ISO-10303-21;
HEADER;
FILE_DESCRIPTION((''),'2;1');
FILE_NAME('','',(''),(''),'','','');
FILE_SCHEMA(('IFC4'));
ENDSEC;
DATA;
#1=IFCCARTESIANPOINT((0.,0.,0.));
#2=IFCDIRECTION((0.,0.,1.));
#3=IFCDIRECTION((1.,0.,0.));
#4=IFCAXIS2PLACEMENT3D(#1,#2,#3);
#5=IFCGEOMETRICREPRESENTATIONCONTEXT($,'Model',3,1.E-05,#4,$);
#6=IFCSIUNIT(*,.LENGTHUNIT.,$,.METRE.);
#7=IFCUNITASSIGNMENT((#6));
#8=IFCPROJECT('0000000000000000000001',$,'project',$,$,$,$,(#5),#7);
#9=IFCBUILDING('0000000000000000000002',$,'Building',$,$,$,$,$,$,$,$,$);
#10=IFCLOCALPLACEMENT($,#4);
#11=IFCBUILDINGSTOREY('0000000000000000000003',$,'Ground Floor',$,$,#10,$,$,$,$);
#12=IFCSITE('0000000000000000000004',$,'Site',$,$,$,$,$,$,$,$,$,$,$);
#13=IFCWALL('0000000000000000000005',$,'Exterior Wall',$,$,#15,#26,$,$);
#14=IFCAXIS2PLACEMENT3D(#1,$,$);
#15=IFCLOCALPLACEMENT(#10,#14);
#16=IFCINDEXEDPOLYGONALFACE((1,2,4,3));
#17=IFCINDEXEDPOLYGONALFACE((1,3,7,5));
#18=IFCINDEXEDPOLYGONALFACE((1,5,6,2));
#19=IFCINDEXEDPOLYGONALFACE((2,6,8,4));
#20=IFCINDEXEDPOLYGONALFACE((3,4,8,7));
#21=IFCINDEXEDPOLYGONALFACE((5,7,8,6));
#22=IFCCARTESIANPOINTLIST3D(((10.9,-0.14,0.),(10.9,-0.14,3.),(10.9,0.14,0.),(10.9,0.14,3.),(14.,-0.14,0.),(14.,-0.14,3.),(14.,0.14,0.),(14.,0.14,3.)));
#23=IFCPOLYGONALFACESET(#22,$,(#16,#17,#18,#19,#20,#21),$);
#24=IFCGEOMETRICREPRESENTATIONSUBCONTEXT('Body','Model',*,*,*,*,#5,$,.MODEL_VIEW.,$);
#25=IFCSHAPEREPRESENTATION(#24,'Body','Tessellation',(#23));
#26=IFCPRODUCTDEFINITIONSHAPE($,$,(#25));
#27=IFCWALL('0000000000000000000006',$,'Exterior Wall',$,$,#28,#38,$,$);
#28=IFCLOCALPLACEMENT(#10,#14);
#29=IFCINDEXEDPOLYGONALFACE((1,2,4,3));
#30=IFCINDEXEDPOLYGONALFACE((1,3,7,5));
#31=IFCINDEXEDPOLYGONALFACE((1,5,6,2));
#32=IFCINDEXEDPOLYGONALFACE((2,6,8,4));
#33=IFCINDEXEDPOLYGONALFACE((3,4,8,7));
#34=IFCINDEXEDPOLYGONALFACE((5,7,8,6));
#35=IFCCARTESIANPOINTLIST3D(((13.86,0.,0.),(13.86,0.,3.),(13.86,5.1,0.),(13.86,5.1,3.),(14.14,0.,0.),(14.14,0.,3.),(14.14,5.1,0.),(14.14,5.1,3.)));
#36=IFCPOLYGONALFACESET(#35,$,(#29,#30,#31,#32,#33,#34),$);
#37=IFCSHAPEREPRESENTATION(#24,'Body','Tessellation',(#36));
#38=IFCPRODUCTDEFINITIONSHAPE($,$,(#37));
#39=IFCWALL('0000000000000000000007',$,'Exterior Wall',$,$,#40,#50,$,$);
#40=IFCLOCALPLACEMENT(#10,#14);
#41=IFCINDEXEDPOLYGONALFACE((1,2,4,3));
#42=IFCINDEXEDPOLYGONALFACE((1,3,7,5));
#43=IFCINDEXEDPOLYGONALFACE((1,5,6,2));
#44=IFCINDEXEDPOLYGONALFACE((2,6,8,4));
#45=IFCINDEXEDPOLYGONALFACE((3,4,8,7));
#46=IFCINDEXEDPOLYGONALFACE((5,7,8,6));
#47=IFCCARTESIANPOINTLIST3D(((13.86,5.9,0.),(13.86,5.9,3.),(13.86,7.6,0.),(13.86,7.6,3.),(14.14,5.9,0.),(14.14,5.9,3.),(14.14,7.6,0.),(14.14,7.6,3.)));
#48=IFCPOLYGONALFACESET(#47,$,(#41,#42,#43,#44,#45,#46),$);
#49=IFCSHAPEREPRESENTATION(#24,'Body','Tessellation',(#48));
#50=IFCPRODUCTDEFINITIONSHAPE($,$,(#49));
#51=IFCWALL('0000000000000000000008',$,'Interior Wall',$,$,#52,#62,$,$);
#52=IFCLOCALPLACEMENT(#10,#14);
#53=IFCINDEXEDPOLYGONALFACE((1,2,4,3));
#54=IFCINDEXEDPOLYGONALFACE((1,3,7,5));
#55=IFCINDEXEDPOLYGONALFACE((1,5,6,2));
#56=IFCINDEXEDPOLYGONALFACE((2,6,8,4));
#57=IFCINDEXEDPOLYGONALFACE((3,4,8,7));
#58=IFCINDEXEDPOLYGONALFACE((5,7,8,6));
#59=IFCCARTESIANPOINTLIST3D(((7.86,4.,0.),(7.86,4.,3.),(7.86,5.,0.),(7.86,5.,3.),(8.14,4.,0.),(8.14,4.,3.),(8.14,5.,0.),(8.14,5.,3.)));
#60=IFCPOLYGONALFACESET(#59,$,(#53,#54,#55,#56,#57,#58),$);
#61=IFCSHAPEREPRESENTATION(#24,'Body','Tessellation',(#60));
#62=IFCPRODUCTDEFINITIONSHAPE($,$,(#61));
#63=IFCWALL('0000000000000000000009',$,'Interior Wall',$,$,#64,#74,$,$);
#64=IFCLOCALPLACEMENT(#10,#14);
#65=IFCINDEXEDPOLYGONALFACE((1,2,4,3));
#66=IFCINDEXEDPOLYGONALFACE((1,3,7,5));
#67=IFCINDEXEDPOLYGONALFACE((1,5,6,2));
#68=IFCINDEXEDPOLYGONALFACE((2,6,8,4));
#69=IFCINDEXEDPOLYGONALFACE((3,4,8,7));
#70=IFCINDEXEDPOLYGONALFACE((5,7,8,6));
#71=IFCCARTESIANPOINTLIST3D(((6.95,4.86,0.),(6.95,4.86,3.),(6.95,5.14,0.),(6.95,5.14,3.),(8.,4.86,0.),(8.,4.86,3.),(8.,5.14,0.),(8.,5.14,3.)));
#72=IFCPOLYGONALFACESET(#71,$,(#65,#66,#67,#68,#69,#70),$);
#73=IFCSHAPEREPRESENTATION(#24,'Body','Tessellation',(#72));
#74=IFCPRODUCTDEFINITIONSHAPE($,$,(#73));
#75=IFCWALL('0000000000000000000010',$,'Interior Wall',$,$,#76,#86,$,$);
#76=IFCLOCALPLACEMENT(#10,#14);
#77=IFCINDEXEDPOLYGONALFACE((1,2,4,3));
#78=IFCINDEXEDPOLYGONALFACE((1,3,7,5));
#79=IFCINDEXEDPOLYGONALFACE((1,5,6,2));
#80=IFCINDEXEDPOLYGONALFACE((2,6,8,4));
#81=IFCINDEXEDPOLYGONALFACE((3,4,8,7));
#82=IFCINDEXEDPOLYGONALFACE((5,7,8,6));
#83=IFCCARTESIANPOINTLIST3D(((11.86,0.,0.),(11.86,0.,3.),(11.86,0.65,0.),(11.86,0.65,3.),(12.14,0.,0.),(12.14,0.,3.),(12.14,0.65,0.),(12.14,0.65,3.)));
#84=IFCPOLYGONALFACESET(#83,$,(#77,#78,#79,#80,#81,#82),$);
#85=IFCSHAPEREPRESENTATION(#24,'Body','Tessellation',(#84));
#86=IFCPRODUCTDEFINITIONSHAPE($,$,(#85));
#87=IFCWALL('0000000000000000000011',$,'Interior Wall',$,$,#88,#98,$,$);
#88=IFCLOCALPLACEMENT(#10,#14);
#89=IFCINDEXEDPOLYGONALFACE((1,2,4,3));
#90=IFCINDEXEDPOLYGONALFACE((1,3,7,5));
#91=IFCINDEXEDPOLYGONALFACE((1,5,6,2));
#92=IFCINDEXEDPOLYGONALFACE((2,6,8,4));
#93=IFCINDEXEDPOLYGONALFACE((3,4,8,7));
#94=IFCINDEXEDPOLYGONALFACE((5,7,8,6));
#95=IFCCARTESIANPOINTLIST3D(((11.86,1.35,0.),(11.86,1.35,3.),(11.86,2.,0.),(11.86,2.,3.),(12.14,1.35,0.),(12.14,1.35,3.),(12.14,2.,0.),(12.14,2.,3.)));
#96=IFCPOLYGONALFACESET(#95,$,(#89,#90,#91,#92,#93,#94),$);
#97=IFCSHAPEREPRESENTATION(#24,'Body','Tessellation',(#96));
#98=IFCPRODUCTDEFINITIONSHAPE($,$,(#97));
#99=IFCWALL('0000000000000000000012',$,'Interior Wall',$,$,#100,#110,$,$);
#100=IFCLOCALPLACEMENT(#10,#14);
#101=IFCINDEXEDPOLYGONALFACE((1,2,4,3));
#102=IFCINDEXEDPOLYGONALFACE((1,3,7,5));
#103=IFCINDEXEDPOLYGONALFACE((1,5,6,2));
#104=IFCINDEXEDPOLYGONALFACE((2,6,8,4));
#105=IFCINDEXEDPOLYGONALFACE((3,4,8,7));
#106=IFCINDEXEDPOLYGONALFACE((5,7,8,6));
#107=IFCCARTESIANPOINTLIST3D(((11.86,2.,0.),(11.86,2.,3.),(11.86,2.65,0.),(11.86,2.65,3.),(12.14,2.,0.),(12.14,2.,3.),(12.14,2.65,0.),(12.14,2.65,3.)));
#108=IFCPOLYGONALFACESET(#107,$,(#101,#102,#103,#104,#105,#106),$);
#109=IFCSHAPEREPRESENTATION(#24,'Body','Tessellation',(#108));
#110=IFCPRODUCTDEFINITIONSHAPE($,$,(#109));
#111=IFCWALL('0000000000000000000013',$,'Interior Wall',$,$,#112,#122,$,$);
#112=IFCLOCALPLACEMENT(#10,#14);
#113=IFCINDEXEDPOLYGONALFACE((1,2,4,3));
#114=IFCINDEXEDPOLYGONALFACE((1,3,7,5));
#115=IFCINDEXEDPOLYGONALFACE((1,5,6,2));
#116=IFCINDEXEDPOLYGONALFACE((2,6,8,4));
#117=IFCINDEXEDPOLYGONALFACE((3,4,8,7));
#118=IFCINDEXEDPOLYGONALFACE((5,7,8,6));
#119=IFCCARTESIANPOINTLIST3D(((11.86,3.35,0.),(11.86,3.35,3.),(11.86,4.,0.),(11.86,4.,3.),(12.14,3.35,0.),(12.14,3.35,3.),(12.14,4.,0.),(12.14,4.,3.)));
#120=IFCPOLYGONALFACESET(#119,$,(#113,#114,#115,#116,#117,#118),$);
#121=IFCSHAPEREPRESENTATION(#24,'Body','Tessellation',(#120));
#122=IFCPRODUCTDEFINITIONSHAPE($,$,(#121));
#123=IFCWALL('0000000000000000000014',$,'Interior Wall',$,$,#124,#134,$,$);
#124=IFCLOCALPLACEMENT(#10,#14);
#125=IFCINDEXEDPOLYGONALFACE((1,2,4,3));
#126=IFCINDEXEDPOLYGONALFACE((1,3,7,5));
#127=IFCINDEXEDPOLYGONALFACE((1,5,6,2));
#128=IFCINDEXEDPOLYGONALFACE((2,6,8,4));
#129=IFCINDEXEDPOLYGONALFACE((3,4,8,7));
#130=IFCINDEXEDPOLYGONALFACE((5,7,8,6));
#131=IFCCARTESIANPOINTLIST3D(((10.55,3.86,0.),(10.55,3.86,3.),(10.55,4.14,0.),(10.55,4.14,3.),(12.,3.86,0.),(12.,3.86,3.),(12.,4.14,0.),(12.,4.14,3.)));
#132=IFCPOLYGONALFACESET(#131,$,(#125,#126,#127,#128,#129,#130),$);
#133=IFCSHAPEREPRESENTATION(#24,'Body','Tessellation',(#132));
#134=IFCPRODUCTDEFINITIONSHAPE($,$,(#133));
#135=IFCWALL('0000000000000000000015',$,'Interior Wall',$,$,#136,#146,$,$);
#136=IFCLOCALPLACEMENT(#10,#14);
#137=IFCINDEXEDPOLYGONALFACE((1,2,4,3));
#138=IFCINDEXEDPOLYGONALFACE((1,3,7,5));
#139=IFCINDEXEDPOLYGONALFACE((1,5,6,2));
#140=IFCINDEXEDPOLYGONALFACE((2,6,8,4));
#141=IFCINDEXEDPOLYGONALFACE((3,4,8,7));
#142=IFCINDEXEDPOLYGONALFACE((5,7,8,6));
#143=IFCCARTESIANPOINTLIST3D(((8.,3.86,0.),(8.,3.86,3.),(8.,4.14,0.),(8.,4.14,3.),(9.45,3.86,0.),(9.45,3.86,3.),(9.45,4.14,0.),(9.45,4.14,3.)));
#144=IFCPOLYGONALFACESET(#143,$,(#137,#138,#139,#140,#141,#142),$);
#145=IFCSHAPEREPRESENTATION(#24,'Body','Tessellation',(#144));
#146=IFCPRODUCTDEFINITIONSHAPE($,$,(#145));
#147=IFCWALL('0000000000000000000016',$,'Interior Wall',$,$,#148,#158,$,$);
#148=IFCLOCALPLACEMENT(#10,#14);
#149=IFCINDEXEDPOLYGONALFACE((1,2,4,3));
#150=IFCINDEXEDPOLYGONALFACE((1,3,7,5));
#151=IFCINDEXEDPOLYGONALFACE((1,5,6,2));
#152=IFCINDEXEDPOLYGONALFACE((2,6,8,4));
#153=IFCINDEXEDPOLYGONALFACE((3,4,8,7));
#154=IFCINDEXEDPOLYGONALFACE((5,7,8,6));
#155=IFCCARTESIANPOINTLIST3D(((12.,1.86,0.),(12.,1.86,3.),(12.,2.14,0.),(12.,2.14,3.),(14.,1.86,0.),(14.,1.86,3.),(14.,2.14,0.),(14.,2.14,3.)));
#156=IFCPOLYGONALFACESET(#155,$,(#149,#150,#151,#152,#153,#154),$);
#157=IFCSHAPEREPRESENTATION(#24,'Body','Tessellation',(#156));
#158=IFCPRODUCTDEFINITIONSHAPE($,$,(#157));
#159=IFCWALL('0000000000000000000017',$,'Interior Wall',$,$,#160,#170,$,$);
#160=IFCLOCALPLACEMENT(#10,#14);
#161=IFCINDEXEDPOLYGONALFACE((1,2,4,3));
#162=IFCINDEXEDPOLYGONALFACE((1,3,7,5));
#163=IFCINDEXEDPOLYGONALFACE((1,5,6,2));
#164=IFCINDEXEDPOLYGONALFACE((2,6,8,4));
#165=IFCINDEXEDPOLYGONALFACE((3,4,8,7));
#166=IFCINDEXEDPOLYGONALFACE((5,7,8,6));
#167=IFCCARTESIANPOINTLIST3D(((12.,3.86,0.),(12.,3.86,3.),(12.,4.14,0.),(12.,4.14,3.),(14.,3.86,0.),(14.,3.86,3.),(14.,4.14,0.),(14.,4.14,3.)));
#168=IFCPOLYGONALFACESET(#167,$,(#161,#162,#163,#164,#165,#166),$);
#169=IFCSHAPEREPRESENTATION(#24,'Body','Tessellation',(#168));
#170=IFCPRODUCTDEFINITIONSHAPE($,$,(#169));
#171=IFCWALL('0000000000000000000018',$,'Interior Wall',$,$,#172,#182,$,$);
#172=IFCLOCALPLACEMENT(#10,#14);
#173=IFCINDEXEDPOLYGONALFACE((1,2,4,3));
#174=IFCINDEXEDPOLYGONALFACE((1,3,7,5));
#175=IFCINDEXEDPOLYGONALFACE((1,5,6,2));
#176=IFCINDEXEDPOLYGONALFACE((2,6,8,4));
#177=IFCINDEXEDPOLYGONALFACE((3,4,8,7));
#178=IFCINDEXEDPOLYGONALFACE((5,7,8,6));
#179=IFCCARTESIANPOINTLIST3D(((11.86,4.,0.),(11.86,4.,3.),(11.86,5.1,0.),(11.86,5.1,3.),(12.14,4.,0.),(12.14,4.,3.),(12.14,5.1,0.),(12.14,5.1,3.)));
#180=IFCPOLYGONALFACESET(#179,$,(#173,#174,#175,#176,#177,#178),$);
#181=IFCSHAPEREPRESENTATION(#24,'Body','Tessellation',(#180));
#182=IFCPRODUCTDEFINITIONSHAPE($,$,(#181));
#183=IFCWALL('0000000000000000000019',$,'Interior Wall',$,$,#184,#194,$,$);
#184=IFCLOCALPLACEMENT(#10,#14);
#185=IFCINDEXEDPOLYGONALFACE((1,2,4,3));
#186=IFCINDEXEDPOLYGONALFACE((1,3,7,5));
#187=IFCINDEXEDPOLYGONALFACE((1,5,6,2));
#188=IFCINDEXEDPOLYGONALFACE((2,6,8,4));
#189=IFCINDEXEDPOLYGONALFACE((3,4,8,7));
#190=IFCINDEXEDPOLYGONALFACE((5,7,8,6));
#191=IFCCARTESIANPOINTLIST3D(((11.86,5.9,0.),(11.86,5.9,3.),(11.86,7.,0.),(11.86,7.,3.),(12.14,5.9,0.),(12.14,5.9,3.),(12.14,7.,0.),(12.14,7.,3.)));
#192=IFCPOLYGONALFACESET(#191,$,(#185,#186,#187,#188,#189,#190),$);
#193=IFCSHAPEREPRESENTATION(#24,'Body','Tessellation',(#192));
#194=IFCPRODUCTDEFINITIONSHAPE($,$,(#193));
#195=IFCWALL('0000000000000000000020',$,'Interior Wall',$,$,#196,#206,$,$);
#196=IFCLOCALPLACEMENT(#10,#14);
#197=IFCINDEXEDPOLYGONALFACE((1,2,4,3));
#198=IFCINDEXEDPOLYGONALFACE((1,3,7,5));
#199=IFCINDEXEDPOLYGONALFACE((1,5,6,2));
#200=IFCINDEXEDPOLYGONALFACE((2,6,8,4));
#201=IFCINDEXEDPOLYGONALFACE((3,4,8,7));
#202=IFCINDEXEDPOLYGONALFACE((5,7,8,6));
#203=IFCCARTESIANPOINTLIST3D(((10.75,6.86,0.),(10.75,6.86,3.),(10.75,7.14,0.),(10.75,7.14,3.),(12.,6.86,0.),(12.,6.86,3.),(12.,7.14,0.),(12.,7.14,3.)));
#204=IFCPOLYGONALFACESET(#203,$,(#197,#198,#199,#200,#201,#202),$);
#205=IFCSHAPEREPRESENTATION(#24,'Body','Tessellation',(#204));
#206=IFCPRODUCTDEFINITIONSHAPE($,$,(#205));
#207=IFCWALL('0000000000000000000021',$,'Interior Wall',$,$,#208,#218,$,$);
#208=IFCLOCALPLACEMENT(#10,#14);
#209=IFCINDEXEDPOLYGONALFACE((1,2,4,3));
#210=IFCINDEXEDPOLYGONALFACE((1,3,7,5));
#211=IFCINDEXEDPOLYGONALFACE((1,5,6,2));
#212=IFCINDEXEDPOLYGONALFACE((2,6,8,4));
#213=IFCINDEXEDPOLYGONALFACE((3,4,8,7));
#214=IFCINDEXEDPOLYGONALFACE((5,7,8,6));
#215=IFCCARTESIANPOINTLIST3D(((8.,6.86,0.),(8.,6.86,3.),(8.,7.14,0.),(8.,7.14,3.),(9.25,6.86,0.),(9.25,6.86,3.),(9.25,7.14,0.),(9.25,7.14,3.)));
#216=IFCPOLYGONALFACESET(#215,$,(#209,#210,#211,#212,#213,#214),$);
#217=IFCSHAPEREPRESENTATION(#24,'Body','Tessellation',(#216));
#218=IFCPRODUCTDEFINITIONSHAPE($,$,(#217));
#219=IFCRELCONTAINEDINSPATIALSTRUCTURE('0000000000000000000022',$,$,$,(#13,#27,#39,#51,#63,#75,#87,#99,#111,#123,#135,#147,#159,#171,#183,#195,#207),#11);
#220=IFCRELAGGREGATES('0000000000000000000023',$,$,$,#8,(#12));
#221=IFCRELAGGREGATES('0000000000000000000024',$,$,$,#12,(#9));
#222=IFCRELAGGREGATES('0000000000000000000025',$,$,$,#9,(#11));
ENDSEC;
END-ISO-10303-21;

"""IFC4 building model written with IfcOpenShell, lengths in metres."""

from ifc_helpers import new_model, si_unit, frame, origin_with_axes, place, context, subcontext, project, spatial, indexed_curve, outline, extrude, element, save


model = new_model("IFC4")

# Units and contexts
model_context = context("Model", 3, precision=1e-05, world=origin_with_axes())
body_context = subcontext(model_context, "Body", "Model", "MODEL_VIEW")
ifc_project = project(units=[si_unit("LENGTHUNIT", "METRE")], contexts=[model_context])

# Site, building, storey
site = spatial("IfcSite", under=ifc_project, Name="Site")
building = spatial("IfcBuilding", under=site, Name="Building")
storey_placement = place(None, origin_with_axes())
storey = spatial("IfcBuildingStorey", under=building, at=storey_placement, Name="Ground Floor")

# Walls
wall_1_placement = place(storey_placement, frame((10.9, 0.0, 0.0), z_axis=(0.0, 0.0, 1.0), x_axis=(1.0, 0.0, 0.0)))
element("IfcWall", 1, at=wall_1_placement, inside=storey, Name="Exterior Wall", context=body_context, shape_type="SweptSolid", body=[
    extrude(outline(indexed_curve([(0.0, 0.0), (0.0, 0.28), (3.1, 0.28), (3.1, 0.0), (0.0, 0.0)], self_intersect=False)), frame((0.0, -0.14, 0.0), z_axis=(0.0, 0.0, 1.0), x_axis=(1.0, 0.0, 0.0)), (0.0, 0.0, 1.0), 3.0),
])
wall_2_placement = place(storey_placement, frame((14.0, 0.0, 0.0), z_axis=(0.0, 0.0, 1.0), x_axis=(0.0, 1.0, 0.0)))
element("IfcWall", 2, at=wall_2_placement, inside=storey, Name="Exterior Wall", context=body_context, shape_type="SweptSolid", body=[
    extrude(outline(indexed_curve([(0.0, 0.0), (0.0, 0.28), (5.1, 0.28), (5.1, 0.0), (0.0, 0.0)], self_intersect=False)), frame((0.0, -0.14, 0.0), z_axis=(0.0, 0.0, 1.0), x_axis=(1.0, 0.0, 0.0)), (0.0, 0.0, 1.0), 3.0),
])
wall_3_placement = place(storey_placement, frame((14.0, 5.9, 0.0), z_axis=(0.0, 0.0, 1.0), x_axis=(0.0, 1.0, 0.0)))
element("IfcWall", 3, at=wall_3_placement, inside=storey, Name="Exterior Wall", context=body_context, shape_type="SweptSolid", body=[
    extrude(outline(indexed_curve([(0.0, 0.0), (0.0, 0.28), (1.7, 0.28), (1.7, 0.0), (0.0, 0.0)], self_intersect=False)), frame((0.0, -0.14, 0.0), z_axis=(0.0, 0.0, 1.0), x_axis=(1.0, 0.0, 0.0)), (0.0, 0.0, 1.0), 3.0),
])
wall_4_placement = place(storey_placement, frame((8.0, 4.0, 0.0), z_axis=(0.0, 0.0, 1.0), x_axis=(0.0, 1.0, 0.0)))
element("IfcWall", 4, at=wall_4_placement, inside=storey, Name="Interior Wall", context=body_context, shape_type="SweptSolid", body=[
    extrude(outline(indexed_curve([(0.0, 0.0), (0.0, 0.28), (1.0, 0.28), (1.0, 0.0), (0.0, 0.0)], self_intersect=False)), frame((0.0, -0.14, 0.0), z_axis=(0.0, 0.0, 1.0), x_axis=(1.0, 0.0, 0.0)), (0.0, 0.0, 1.0), 3.0),
])
wall_5_placement = place(storey_placement, frame((8.0, 5.0, 0.0), z_axis=(0.0, 0.0, 1.0), x_axis=(-1.0, 0.0, 0.0)))
element("IfcWall", 5, at=wall_5_placement, inside=storey, Name="Interior Wall", context=body_context, shape_type="SweptSolid", body=[
    extrude(outline(indexed_curve([(0.0, 0.0), (0.0, 0.28), (1.05, 0.28), (1.05, 0.0), (0.0, 0.0)], self_intersect=False)), frame((0.0, -0.14, 0.0), z_axis=(0.0, 0.0, 1.0), x_axis=(1.0, 0.0, 0.0)), (0.0, 0.0, 1.0), 3.0),
])
wall_6_placement = place(storey_placement, frame((12.0, 0.0, 0.0), z_axis=(0.0, 0.0, 1.0), x_axis=(0.0, 1.0, 0.0)))
element("IfcWall", 6, at=wall_6_placement, inside=storey, Name="Interior Wall", context=body_context, shape_type="SweptSolid", body=[
    extrude(outline(indexed_curve([(0.0, 0.0), (0.0, 0.28), (0.65, 0.28), (0.65, 0.0), (0.0, 0.0)], self_intersect=False)), frame((0.0, -0.14, 0.0), z_axis=(0.0, 0.0, 1.0), x_axis=(1.0, 0.0, 0.0)), (0.0, 0.0, 1.0), 3.0),
])
for number, where, z_axis, x_axis, name in (
    (7, (12.0, 1.35, 0.0), (0.0, 0.0, 1.0), (0.0, 1.0, 0.0), "Interior Wall"),
    (8, (12.0, 2.0, 0.0), (0.0, 0.0, 1.0), (0.0, 1.0, 0.0), "Interior Wall"),
    (9, (12.0, 3.35, 0.0), (0.0, 0.0, 1.0), (0.0, 1.0, 0.0), "Interior Wall"),
):
    element("IfcWall", number, at=place(storey_placement, frame(where, z_axis=z_axis, x_axis=x_axis)), inside=storey, Name=name, context=body_context, shape_type="SweptSolid", body=[
        extrude(outline(indexed_curve([(0.0, 0.0), (0.0, 0.28), (0.65, 0.28), (0.65, 0.0), (0.0, 0.0)], self_intersect=False)), frame((0.0, -0.14, 0.0), z_axis=(0.0, 0.0, 1.0), x_axis=(1.0, 0.0, 0.0)), (0.0, 0.0, 1.0), 3.0),
    ])
for number, where, z_axis, x_axis, name in (
    (10, (12.0, 4.0, 0.0), (0.0, 0.0, 1.0), (-1.0, 0.0, 0.0), "Interior Wall"),
    (11, (9.45, 4.0, 0.0), (0.0, 0.0, 1.0), (-1.0, 0.0, 0.0), "Interior Wall"),
):
    element("IfcWall", number, at=place(storey_placement, frame(where, z_axis=z_axis, x_axis=x_axis)), inside=storey, Name=name, context=body_context, shape_type="SweptSolid", body=[
        extrude(outline(indexed_curve([(0.0, 0.0), (0.0, 0.28), (1.45, 0.28), (1.45, 0.0), (0.0, 0.0)], self_intersect=False)), frame((0.0, -0.14, 0.0), z_axis=(0.0, 0.0, 1.0), x_axis=(1.0, 0.0, 0.0)), (0.0, 0.0, 1.0), 3.0),
    ])
for number, where, z_axis, x_axis, name in (
    (12, (14.0, 2.0, 0.0), (0.0, 0.0, 1.0), (-1.0, 0.0, 0.0), "Interior Wall"),
    (13, (14.0, 4.0, 0.0), (0.0, 0.0, 1.0), (-1.0, 0.0, 0.0), "Interior Wall"),
):
    element("IfcWall", number, at=place(storey_placement, frame(where, z_axis=z_axis, x_axis=x_axis)), inside=storey, Name=name, context=body_context, shape_type="SweptSolid", body=[
        extrude(outline(indexed_curve([(0.0, 0.0), (0.0, 0.28), (2.0, 0.28), (2.0, 0.0), (0.0, 0.0)], self_intersect=False)), frame((0.0, -0.14, 0.0), z_axis=(0.0, 0.0, 1.0), x_axis=(1.0, 0.0, 0.0)), (0.0, 0.0, 1.0), 3.0),
    ])
for number, where, z_axis, x_axis, name in (
    (14, (12.0, 4.0, 0.0), (0.0, 0.0, 1.0), (0.0, 1.0, 0.0), "Interior Wall"),
    (15, (12.0, 5.9, 0.0), (0.0, 0.0, 1.0), (0.0, 1.0, 0.0), "Interior Wall"),
):
    element("IfcWall", number, at=place(storey_placement, frame(where, z_axis=z_axis, x_axis=x_axis)), inside=storey, Name=name, context=body_context, shape_type="SweptSolid", body=[
        extrude(outline(indexed_curve([(0.0, 0.0), (0.0, 0.28), (1.1, 0.28), (1.1, 0.0), (0.0, 0.0)], self_intersect=False)), frame((0.0, -0.14, 0.0), z_axis=(0.0, 0.0, 1.0), x_axis=(1.0, 0.0, 0.0)), (0.0, 0.0, 1.0), 3.0),
    ])
for number, where, z_axis, x_axis, name in (
    (16, (12.0, 7.0, 0.0), (0.0, 0.0, 1.0), (-1.0, 0.0, 0.0), "Interior Wall"),
    (17, (9.25, 7.0, 0.0), (0.0, 0.0, 1.0), (-1.0, 0.0, 0.0), "Interior Wall"),
):
    element("IfcWall", number, at=place(storey_placement, frame(where, z_axis=z_axis, x_axis=x_axis)), inside=storey, Name=name, context=body_context, shape_type="SweptSolid", body=[
        extrude(outline(indexed_curve([(0.0, 0.0), (0.0, 0.28), (1.25, 0.28), (1.25, 0.0), (0.0, 0.0)], self_intersect=False)), frame((0.0, -0.14, 0.0), z_axis=(0.0, 0.0, 1.0), x_axis=(1.0, 0.0, 0.0)), (0.0, 0.0, 1.0), 3.0),
    ])

save(model, "model.ifc")
